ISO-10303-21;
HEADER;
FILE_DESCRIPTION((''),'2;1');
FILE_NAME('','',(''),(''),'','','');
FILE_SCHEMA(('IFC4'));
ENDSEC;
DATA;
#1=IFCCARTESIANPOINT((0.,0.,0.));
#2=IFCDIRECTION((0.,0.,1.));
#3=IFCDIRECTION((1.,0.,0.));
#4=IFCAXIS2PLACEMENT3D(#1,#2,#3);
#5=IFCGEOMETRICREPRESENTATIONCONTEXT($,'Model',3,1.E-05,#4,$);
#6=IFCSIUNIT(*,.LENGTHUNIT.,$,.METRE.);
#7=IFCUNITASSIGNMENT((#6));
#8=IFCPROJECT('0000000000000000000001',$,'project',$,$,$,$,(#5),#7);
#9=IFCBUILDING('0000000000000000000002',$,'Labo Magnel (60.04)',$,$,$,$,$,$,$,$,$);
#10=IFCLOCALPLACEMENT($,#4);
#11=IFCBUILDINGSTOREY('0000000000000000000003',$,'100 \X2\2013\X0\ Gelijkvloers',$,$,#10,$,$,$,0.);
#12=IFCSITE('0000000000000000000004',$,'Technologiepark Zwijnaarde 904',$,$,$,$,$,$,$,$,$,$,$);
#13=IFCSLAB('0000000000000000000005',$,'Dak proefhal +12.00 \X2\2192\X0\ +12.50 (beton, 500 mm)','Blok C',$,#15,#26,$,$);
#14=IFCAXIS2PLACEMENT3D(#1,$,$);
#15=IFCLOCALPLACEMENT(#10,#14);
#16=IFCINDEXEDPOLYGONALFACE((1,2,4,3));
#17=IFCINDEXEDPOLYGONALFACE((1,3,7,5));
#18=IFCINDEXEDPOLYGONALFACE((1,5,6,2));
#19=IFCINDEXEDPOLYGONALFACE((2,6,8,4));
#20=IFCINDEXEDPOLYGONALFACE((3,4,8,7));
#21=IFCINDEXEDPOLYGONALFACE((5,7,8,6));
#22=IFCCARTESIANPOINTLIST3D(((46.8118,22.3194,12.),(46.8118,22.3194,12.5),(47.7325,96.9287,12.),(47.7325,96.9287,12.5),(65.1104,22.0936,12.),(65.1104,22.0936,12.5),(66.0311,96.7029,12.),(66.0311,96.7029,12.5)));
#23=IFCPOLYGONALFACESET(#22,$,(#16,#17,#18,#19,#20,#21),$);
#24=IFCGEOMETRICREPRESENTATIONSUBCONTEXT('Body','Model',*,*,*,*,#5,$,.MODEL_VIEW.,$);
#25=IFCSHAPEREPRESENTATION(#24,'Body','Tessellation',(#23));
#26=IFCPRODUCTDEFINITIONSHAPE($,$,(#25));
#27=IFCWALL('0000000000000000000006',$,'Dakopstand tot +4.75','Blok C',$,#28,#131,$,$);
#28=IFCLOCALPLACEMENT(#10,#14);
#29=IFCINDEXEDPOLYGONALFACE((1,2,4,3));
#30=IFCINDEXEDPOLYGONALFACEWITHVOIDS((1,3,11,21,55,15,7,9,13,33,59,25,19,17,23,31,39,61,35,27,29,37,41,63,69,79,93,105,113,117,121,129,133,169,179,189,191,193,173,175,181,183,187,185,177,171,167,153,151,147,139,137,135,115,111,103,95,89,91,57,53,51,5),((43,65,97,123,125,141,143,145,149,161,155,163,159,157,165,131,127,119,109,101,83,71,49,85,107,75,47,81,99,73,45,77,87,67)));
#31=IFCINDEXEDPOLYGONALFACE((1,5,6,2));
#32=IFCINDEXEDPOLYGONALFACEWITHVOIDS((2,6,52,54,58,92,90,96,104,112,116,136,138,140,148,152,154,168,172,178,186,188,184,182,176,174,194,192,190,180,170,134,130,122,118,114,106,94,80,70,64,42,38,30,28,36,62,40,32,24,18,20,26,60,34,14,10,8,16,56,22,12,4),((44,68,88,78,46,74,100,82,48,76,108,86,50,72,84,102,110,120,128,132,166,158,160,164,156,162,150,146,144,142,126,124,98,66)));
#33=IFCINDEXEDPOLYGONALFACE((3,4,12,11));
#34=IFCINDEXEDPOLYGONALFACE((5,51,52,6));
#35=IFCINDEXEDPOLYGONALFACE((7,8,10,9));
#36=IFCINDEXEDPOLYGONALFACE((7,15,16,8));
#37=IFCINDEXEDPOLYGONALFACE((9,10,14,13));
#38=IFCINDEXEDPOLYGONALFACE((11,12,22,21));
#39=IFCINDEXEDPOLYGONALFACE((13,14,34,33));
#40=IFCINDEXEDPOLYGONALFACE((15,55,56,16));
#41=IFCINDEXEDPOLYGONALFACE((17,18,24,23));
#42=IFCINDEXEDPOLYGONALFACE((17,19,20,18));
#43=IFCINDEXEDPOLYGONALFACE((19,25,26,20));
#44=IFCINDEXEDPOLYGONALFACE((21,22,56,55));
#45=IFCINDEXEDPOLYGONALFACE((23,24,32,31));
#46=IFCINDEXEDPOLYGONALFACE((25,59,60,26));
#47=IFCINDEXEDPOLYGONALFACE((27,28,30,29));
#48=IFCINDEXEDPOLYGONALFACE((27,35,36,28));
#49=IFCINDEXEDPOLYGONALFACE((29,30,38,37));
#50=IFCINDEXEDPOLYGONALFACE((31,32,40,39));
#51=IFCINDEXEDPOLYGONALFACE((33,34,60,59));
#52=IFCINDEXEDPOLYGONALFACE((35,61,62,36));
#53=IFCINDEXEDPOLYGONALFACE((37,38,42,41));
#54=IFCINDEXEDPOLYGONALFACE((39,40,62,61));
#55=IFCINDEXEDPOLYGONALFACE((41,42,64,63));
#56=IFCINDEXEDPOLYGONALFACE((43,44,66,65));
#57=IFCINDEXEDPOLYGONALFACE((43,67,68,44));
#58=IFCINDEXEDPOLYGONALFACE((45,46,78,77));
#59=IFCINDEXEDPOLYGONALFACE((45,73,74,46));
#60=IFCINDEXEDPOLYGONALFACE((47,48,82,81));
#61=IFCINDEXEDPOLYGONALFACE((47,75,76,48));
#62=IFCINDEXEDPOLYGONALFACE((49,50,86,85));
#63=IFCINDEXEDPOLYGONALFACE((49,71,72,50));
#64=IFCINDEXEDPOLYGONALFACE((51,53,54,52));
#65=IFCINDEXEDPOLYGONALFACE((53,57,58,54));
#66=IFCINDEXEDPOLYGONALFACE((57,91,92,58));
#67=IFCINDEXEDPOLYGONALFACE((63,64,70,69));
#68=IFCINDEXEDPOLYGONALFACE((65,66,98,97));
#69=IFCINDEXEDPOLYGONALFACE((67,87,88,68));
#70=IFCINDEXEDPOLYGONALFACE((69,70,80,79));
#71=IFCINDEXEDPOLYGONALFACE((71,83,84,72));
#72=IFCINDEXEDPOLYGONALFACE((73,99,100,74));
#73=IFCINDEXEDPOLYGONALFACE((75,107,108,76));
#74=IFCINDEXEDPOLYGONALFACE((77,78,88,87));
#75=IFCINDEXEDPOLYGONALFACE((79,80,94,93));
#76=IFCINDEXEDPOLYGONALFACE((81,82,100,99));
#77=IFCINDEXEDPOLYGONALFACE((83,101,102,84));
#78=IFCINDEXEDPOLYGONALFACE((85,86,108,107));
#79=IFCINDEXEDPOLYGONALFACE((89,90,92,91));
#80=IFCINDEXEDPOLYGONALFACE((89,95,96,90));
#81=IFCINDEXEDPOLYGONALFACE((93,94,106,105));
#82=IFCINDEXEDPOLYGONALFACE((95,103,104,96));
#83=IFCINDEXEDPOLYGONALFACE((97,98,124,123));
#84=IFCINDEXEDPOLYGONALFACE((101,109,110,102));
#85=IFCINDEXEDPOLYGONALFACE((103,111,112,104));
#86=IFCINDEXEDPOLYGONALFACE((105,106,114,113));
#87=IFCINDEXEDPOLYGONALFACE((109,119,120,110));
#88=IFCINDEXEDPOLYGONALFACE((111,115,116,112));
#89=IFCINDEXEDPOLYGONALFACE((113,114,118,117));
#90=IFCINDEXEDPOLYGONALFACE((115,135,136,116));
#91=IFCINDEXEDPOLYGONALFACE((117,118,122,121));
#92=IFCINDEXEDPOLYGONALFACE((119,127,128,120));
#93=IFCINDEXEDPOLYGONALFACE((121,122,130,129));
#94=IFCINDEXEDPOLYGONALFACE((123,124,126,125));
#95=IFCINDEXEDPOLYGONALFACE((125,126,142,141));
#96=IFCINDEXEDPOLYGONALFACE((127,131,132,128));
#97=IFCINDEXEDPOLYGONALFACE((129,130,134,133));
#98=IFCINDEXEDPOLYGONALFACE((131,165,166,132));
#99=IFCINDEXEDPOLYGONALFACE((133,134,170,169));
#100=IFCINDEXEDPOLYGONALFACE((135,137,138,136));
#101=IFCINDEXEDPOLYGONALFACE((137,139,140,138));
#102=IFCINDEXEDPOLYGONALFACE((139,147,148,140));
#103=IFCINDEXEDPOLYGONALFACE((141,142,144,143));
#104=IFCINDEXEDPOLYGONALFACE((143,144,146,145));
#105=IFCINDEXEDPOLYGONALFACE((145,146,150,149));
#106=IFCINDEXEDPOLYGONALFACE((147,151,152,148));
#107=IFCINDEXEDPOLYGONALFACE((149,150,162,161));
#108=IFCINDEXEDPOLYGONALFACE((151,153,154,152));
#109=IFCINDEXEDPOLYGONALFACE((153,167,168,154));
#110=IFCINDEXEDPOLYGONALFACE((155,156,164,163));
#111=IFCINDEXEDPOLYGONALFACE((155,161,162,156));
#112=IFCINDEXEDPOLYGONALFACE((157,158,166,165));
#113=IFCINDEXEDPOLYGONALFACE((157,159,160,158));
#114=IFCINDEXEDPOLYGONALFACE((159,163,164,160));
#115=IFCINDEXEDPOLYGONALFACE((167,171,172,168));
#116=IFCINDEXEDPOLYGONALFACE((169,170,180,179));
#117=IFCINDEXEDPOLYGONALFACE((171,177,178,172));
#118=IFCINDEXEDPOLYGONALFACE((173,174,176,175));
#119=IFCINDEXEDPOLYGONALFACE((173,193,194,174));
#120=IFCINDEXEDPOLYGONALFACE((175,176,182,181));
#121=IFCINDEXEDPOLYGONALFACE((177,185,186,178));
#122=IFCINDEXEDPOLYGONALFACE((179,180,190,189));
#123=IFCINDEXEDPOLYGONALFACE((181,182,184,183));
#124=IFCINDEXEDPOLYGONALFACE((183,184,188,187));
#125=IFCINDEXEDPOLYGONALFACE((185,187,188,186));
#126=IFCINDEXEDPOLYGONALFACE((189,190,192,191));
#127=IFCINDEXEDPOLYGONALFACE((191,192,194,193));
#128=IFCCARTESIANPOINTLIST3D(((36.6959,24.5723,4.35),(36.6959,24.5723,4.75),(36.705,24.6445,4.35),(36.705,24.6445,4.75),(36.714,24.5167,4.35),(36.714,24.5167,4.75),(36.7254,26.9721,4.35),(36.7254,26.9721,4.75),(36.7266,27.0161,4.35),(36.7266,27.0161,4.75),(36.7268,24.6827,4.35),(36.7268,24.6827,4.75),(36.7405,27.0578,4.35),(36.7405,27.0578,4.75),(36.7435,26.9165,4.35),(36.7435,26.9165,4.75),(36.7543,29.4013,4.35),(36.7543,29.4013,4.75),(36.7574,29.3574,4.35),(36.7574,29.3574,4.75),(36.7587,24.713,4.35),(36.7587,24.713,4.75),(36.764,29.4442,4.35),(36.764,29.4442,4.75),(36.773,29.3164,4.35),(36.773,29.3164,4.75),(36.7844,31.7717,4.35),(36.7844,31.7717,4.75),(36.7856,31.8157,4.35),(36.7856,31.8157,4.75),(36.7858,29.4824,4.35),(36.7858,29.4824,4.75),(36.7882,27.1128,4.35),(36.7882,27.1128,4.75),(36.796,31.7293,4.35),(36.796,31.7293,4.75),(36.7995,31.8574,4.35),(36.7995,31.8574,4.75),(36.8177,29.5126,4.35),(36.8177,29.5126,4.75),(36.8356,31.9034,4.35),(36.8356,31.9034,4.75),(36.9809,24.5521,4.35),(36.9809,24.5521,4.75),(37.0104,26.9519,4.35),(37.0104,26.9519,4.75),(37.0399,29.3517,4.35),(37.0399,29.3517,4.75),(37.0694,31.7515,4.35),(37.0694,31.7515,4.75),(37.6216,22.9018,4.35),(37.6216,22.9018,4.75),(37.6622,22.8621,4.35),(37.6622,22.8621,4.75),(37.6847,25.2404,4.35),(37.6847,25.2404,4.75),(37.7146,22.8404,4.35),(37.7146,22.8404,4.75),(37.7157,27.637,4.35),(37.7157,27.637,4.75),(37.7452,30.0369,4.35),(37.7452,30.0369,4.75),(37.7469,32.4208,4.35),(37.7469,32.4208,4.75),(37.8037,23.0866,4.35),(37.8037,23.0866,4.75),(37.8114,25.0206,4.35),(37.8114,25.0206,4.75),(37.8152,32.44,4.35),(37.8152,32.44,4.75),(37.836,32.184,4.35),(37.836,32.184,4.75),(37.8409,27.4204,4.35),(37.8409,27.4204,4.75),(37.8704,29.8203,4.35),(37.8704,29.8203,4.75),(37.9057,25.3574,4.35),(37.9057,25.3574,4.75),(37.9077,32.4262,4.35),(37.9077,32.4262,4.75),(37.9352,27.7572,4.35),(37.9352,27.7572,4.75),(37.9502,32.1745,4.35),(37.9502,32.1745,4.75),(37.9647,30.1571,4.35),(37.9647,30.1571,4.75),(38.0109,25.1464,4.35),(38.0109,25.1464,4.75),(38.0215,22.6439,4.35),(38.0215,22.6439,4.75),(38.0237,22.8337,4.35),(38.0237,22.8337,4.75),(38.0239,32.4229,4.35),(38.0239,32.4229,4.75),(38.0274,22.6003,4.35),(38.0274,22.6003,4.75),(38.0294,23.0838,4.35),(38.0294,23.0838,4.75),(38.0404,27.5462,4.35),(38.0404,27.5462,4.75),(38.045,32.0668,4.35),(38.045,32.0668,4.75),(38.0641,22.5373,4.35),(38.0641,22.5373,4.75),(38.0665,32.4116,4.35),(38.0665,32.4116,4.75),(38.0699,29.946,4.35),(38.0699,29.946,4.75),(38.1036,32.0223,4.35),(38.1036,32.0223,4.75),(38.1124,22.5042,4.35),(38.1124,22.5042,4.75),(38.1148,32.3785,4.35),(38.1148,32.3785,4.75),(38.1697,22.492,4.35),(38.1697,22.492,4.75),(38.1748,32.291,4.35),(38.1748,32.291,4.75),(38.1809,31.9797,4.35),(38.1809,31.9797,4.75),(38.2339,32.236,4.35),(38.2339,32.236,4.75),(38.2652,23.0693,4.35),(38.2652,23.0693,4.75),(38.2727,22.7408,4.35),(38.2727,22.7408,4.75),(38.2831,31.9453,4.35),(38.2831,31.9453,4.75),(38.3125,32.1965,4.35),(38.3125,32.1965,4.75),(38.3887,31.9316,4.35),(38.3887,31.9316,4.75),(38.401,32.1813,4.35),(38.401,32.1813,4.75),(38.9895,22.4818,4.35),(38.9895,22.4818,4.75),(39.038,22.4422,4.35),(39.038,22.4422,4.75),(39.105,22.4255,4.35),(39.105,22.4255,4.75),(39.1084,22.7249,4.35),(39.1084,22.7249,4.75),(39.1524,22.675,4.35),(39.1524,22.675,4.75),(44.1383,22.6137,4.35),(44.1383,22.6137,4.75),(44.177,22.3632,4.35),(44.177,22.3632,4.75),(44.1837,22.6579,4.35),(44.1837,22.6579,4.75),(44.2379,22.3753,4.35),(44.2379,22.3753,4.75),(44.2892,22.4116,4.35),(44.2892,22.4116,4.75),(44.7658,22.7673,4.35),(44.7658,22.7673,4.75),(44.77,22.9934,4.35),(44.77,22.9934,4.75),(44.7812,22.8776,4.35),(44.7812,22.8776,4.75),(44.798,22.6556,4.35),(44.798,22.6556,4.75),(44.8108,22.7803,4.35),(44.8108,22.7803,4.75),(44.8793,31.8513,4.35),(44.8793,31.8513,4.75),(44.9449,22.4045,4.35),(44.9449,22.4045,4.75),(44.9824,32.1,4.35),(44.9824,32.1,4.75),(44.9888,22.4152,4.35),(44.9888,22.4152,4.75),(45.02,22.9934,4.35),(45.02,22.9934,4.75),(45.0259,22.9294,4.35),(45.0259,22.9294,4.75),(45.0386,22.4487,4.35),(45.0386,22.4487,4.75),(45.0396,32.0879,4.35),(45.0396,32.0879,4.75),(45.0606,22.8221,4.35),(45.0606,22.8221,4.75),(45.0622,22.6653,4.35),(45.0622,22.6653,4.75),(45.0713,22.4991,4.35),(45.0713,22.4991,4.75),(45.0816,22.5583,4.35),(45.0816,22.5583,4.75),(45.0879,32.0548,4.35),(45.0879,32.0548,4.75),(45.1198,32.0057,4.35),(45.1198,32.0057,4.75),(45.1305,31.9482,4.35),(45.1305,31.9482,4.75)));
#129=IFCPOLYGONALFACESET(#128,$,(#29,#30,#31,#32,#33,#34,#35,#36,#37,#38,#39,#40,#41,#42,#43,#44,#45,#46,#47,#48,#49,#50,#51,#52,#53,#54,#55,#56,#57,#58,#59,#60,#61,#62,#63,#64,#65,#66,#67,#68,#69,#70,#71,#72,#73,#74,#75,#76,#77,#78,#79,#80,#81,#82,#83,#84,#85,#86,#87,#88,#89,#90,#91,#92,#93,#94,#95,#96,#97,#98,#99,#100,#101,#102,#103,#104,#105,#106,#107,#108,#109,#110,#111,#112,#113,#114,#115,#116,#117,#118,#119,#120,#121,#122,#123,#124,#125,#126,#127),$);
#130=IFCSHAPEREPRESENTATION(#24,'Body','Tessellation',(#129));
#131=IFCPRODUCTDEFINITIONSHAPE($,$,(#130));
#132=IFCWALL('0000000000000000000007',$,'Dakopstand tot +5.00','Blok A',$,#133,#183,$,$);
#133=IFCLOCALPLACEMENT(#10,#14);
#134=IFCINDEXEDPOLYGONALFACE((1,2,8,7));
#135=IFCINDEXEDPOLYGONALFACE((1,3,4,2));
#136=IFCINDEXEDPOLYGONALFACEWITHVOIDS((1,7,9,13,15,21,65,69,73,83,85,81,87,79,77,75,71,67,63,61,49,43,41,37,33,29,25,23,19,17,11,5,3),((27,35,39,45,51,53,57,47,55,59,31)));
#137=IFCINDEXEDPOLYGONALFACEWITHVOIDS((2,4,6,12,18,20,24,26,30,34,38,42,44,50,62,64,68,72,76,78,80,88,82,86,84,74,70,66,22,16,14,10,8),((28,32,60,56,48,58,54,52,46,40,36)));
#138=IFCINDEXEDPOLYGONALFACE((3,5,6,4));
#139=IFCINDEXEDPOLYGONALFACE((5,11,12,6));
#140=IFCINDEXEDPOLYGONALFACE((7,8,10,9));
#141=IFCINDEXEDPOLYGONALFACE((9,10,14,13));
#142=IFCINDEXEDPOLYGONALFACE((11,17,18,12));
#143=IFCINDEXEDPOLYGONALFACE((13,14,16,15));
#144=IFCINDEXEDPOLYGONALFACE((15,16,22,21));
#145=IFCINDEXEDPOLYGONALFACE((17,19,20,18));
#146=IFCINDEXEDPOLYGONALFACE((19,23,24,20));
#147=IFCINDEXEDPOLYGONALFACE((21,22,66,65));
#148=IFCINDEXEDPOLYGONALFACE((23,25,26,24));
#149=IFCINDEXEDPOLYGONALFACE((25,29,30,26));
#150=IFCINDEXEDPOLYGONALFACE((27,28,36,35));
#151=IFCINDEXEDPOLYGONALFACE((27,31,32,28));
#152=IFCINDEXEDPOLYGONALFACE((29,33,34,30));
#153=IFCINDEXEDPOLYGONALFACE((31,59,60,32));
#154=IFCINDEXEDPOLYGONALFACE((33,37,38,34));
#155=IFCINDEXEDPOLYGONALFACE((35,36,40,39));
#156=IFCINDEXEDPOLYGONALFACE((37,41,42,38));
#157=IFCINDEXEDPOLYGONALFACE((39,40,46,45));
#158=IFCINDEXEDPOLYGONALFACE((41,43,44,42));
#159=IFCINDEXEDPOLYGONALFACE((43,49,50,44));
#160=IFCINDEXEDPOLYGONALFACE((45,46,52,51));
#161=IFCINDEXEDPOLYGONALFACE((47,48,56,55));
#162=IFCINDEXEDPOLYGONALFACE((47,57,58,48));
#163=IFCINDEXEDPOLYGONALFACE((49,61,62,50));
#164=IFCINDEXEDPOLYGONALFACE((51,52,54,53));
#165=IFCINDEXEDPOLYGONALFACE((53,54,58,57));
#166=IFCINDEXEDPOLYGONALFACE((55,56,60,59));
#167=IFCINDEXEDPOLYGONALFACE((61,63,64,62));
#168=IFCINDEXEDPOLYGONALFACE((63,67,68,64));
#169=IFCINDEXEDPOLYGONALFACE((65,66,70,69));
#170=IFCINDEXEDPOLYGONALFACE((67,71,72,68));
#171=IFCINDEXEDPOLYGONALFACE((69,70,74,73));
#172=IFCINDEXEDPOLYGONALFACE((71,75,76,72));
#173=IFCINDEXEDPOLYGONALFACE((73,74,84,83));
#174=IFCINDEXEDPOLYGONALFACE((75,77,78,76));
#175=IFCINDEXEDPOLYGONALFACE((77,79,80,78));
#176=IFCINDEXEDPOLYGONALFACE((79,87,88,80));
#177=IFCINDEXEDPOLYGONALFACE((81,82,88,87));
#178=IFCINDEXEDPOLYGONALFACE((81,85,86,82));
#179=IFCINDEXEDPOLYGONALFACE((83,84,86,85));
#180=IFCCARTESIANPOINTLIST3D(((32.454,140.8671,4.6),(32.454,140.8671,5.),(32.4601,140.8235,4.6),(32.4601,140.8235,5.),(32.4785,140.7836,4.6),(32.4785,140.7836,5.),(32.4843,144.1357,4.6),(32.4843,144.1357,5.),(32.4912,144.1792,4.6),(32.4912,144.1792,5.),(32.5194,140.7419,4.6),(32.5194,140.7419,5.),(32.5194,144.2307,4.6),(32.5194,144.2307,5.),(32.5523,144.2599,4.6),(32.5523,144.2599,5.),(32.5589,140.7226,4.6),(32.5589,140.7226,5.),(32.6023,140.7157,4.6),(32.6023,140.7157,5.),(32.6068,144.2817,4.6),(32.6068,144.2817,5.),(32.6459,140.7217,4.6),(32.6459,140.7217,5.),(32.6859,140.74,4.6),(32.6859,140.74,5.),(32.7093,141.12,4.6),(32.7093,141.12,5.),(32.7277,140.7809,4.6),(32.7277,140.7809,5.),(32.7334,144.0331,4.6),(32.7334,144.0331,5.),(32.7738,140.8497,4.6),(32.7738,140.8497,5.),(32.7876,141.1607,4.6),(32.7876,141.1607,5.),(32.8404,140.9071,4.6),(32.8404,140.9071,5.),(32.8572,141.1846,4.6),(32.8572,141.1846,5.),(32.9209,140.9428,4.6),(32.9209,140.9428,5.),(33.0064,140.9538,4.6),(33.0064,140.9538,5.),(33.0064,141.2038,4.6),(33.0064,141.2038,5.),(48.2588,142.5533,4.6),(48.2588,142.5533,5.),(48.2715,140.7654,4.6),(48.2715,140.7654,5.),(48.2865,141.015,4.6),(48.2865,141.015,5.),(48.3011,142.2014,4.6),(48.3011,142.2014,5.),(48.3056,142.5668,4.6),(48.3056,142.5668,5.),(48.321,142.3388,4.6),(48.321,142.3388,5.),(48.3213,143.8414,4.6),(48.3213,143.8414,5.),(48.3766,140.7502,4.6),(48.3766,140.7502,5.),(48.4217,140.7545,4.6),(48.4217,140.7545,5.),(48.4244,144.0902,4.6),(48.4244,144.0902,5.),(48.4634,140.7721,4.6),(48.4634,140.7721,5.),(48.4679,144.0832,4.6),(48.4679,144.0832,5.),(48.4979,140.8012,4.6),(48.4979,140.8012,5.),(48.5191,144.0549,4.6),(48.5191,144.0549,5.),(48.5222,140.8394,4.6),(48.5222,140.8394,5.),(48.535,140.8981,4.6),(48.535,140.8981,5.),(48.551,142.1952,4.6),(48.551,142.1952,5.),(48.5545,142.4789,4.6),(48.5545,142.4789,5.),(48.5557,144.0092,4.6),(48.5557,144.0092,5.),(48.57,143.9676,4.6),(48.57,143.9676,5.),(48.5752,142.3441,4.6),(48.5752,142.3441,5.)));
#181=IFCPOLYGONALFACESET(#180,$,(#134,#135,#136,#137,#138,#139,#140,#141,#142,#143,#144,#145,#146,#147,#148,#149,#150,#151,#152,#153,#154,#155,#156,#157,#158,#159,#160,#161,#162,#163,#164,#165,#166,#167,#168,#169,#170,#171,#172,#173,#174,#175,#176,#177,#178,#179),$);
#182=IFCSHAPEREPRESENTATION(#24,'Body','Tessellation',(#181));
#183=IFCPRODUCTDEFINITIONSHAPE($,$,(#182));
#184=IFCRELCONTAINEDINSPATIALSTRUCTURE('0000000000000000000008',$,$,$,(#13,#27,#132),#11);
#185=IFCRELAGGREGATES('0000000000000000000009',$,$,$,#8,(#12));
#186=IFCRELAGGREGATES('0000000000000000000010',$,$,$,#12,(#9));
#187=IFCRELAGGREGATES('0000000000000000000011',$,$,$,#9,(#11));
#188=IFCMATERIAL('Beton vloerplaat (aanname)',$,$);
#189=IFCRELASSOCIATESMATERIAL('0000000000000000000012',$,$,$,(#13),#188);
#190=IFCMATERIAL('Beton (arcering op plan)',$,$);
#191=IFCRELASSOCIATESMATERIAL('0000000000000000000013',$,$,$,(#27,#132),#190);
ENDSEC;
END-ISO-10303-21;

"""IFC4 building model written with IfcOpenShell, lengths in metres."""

from ifc_helpers import new_model, si_unit, frame, origin, origin_with_axes, place, context, subcontext, project, spatial, polyline, outline, extrude, material, element, save


model = new_model("IFC4")

# Units and contexts
model_context = context("Model", 3, precision=1e-05, world=origin_with_axes())
body_context = subcontext(model_context, "Body", "Model", "MODEL_VIEW")
ifc_project = project(units=[si_unit("LENGTHUNIT", "METRE")], contexts=[model_context])

# Site, building, storey
site = spatial("IfcSite", under=ifc_project, Name="Technologiepark Zwijnaarde 904")
building = spatial("IfcBuilding", under=site, Name="Labo Magnel (60.04)")
storey_placement = place(None, origin_with_axes())
storey = spatial("IfcBuildingStorey", under=building, at=storey_placement, Name="100 – Gelijkvloers", Elevation=0.0)

# Shared definitions
ifc_material_1 = material(Name="Beton (arcering op plan)")

# Slab
ifc_material_2 = material(Name="Beton vloerplaat (aanname)")
slab_1_placement = place(storey_placement, frame((0.0, 0.0, 12.0), z_axis=(0.0, 0.0, 1.0), x_axis=(1.0, 0.0, 0.0)))
element("IfcSlab", 1, at=slab_1_placement, inside=storey, material=ifc_material_2, Name="Dak proefhal +12.00 → +12.50 (beton, 500 mm)", Description="Blok C", context=body_context, shape_type="SweptSolid", body=[
    extrude(outline(polyline([(66.0311, 96.7029), (65.1104, 22.0936), (46.8118, 22.3194), (47.7325, 96.9287), (66.0311, 96.7029)])), origin(), (0.0, 0.0, 1.0), 0.5),
])

# Walls
wall_1_placement = place(storey_placement, frame((0.0, 0.0, 4.35), z_axis=(0.0, 0.0, 1.0), x_axis=(1.0, 0.0, 0.0)))
element("IfcWall", 2, at=wall_1_placement, inside=storey, material=ifc_material_1, Name="Dakopstand tot +4.75", Description="Blok C", context=body_context, shape_type="SweptSolid", body=[
    extrude(outline(polyline([(37.6847, 25.2404), (36.7435, 26.9165), (36.7254, 26.9721), (36.7266, 27.0161), (36.7405, 27.0578), (36.7882, 27.1128), (37.7157, 27.637), (36.773, 29.3164), (36.7574, 29.3574), (36.7543, 29.4013), (36.764, 29.4442), (36.7858, 29.4824), (36.8177, 29.5126), (37.7452, 30.0369), (36.796, 31.7293), (36.7844, 31.7717), (36.7856, 31.8157), (36.7995, 31.8574), (36.8356, 31.9034), (37.7469, 32.4208), (37.8152, 32.44), (37.9077, 32.4262), (38.0239, 32.4229), (38.0665, 32.4116), (38.1148, 32.3785), (38.1748, 32.291), (38.2339, 32.236), (38.3125, 32.1965), (38.401, 32.1813), (44.9824, 32.1), (45.0396, 32.0879), (45.0879, 32.0548), (45.1198, 32.0057), (45.1305, 31.9482), (45.02, 22.9934), (45.0259, 22.9294), (45.0606, 22.8221), (45.0622, 22.6653), (45.0816, 22.5583), (45.0713, 22.4991), (45.0386, 22.4487), (44.9888, 22.4152), (44.9449, 22.4045), (44.2892, 22.4116), (44.2379, 22.3753), (44.177, 22.3632), (39.105, 22.4255), (39.038, 22.4422), (38.9895, 22.4818), (38.1697, 22.492), (38.1124, 22.5042), (38.0641, 22.5373), (38.0274, 22.6003), (38.0215, 22.6439), (38.0237, 22.8337), (37.7146, 22.8404), (37.6622, 22.8621), (37.6216, 22.9018), (36.714, 24.5167), (36.6959, 24.5723), (36.705, 24.6445), (36.7268, 24.6827), (36.7587, 24.713), (37.6847, 25.2404)]), holes=[polyline([(37.8037, 23.0866), (38.0294, 23.0838), (38.2652, 23.0693), (38.2727, 22.7408), (39.1084, 22.7249), (39.1524, 22.675), (44.1383, 22.6137), (44.1837, 22.6579), (44.798, 22.6556), (44.7658, 22.7673), (44.8108, 22.7803), (44.7812, 22.8776), (44.77, 22.9934), (44.8793, 31.8513), (38.3887, 31.9316), (38.2831, 31.9453), (38.1809, 31.9797), (38.1036, 32.0223), (38.045, 32.0668), (37.9502, 32.1745), (37.836, 32.184), (37.0694, 31.7515), (37.9647, 30.1571), (38.0699, 29.946), (37.8704, 29.8203), (37.0399, 29.3517), (37.9352, 27.7572), (38.0404, 27.5462), (37.8409, 27.4204), (37.0104, 26.9519), (37.9057, 25.3574), (38.0109, 25.1464), (37.8114, 25.0206), (36.9809, 24.5521), (37.8037, 23.0866)])]), origin(), (0.0, 0.0, 1.0), 0.4),
])
wall_2_placement = place(storey_placement, frame((0.0, 0.0, 4.6), z_axis=(0.0, 0.0, 1.0), x_axis=(1.0, 0.0, 0.0)))
element("IfcWall", 3, at=wall_2_placement, inside=storey, material=ifc_material_1, Name="Dakopstand tot +5.00", Description="Blok A", context=body_context, shape_type="SweptSolid", body=[
    extrude(outline(polyline([(32.7277, 140.7809), (32.6859, 140.74), (32.6459, 140.7217), (32.6023, 140.7157), (32.5589, 140.7226), (32.5194, 140.7419), (32.4785, 140.7836), (32.4601, 140.8235), (32.454, 140.8671), (32.4843, 144.1357), (32.4912, 144.1792), (32.5194, 144.2307), (32.5523, 144.2599), (32.6068, 144.2817), (48.4244, 144.0902), (48.4679, 144.0832), (48.5191, 144.0549), (48.5557, 144.0092), (48.57, 143.9676), (48.5545, 142.4789), (48.5752, 142.3441), (48.551, 142.1952), (48.535, 140.8981), (48.5222, 140.8394), (48.4979, 140.8012), (48.4634, 140.7721), (48.4217, 140.7545), (48.3766, 140.7502), (48.2715, 140.7654), (33.0064, 140.9538), (32.9209, 140.9428), (32.8404, 140.9071), (32.7738, 140.8497), (32.7277, 140.7809)]), holes=[polyline([(32.7093, 141.12), (32.7876, 141.1607), (32.8572, 141.1846), (33.0064, 141.2038), (48.2865, 141.015), (48.3011, 142.2014), (48.321, 142.3388), (48.2588, 142.5533), (48.3056, 142.5668), (48.3213, 143.8414), (32.7334, 144.0331), (32.7093, 141.12)])]), origin(), (0.0, 0.0, 1.0), 0.4),
])

save(model, "model.ifc")
